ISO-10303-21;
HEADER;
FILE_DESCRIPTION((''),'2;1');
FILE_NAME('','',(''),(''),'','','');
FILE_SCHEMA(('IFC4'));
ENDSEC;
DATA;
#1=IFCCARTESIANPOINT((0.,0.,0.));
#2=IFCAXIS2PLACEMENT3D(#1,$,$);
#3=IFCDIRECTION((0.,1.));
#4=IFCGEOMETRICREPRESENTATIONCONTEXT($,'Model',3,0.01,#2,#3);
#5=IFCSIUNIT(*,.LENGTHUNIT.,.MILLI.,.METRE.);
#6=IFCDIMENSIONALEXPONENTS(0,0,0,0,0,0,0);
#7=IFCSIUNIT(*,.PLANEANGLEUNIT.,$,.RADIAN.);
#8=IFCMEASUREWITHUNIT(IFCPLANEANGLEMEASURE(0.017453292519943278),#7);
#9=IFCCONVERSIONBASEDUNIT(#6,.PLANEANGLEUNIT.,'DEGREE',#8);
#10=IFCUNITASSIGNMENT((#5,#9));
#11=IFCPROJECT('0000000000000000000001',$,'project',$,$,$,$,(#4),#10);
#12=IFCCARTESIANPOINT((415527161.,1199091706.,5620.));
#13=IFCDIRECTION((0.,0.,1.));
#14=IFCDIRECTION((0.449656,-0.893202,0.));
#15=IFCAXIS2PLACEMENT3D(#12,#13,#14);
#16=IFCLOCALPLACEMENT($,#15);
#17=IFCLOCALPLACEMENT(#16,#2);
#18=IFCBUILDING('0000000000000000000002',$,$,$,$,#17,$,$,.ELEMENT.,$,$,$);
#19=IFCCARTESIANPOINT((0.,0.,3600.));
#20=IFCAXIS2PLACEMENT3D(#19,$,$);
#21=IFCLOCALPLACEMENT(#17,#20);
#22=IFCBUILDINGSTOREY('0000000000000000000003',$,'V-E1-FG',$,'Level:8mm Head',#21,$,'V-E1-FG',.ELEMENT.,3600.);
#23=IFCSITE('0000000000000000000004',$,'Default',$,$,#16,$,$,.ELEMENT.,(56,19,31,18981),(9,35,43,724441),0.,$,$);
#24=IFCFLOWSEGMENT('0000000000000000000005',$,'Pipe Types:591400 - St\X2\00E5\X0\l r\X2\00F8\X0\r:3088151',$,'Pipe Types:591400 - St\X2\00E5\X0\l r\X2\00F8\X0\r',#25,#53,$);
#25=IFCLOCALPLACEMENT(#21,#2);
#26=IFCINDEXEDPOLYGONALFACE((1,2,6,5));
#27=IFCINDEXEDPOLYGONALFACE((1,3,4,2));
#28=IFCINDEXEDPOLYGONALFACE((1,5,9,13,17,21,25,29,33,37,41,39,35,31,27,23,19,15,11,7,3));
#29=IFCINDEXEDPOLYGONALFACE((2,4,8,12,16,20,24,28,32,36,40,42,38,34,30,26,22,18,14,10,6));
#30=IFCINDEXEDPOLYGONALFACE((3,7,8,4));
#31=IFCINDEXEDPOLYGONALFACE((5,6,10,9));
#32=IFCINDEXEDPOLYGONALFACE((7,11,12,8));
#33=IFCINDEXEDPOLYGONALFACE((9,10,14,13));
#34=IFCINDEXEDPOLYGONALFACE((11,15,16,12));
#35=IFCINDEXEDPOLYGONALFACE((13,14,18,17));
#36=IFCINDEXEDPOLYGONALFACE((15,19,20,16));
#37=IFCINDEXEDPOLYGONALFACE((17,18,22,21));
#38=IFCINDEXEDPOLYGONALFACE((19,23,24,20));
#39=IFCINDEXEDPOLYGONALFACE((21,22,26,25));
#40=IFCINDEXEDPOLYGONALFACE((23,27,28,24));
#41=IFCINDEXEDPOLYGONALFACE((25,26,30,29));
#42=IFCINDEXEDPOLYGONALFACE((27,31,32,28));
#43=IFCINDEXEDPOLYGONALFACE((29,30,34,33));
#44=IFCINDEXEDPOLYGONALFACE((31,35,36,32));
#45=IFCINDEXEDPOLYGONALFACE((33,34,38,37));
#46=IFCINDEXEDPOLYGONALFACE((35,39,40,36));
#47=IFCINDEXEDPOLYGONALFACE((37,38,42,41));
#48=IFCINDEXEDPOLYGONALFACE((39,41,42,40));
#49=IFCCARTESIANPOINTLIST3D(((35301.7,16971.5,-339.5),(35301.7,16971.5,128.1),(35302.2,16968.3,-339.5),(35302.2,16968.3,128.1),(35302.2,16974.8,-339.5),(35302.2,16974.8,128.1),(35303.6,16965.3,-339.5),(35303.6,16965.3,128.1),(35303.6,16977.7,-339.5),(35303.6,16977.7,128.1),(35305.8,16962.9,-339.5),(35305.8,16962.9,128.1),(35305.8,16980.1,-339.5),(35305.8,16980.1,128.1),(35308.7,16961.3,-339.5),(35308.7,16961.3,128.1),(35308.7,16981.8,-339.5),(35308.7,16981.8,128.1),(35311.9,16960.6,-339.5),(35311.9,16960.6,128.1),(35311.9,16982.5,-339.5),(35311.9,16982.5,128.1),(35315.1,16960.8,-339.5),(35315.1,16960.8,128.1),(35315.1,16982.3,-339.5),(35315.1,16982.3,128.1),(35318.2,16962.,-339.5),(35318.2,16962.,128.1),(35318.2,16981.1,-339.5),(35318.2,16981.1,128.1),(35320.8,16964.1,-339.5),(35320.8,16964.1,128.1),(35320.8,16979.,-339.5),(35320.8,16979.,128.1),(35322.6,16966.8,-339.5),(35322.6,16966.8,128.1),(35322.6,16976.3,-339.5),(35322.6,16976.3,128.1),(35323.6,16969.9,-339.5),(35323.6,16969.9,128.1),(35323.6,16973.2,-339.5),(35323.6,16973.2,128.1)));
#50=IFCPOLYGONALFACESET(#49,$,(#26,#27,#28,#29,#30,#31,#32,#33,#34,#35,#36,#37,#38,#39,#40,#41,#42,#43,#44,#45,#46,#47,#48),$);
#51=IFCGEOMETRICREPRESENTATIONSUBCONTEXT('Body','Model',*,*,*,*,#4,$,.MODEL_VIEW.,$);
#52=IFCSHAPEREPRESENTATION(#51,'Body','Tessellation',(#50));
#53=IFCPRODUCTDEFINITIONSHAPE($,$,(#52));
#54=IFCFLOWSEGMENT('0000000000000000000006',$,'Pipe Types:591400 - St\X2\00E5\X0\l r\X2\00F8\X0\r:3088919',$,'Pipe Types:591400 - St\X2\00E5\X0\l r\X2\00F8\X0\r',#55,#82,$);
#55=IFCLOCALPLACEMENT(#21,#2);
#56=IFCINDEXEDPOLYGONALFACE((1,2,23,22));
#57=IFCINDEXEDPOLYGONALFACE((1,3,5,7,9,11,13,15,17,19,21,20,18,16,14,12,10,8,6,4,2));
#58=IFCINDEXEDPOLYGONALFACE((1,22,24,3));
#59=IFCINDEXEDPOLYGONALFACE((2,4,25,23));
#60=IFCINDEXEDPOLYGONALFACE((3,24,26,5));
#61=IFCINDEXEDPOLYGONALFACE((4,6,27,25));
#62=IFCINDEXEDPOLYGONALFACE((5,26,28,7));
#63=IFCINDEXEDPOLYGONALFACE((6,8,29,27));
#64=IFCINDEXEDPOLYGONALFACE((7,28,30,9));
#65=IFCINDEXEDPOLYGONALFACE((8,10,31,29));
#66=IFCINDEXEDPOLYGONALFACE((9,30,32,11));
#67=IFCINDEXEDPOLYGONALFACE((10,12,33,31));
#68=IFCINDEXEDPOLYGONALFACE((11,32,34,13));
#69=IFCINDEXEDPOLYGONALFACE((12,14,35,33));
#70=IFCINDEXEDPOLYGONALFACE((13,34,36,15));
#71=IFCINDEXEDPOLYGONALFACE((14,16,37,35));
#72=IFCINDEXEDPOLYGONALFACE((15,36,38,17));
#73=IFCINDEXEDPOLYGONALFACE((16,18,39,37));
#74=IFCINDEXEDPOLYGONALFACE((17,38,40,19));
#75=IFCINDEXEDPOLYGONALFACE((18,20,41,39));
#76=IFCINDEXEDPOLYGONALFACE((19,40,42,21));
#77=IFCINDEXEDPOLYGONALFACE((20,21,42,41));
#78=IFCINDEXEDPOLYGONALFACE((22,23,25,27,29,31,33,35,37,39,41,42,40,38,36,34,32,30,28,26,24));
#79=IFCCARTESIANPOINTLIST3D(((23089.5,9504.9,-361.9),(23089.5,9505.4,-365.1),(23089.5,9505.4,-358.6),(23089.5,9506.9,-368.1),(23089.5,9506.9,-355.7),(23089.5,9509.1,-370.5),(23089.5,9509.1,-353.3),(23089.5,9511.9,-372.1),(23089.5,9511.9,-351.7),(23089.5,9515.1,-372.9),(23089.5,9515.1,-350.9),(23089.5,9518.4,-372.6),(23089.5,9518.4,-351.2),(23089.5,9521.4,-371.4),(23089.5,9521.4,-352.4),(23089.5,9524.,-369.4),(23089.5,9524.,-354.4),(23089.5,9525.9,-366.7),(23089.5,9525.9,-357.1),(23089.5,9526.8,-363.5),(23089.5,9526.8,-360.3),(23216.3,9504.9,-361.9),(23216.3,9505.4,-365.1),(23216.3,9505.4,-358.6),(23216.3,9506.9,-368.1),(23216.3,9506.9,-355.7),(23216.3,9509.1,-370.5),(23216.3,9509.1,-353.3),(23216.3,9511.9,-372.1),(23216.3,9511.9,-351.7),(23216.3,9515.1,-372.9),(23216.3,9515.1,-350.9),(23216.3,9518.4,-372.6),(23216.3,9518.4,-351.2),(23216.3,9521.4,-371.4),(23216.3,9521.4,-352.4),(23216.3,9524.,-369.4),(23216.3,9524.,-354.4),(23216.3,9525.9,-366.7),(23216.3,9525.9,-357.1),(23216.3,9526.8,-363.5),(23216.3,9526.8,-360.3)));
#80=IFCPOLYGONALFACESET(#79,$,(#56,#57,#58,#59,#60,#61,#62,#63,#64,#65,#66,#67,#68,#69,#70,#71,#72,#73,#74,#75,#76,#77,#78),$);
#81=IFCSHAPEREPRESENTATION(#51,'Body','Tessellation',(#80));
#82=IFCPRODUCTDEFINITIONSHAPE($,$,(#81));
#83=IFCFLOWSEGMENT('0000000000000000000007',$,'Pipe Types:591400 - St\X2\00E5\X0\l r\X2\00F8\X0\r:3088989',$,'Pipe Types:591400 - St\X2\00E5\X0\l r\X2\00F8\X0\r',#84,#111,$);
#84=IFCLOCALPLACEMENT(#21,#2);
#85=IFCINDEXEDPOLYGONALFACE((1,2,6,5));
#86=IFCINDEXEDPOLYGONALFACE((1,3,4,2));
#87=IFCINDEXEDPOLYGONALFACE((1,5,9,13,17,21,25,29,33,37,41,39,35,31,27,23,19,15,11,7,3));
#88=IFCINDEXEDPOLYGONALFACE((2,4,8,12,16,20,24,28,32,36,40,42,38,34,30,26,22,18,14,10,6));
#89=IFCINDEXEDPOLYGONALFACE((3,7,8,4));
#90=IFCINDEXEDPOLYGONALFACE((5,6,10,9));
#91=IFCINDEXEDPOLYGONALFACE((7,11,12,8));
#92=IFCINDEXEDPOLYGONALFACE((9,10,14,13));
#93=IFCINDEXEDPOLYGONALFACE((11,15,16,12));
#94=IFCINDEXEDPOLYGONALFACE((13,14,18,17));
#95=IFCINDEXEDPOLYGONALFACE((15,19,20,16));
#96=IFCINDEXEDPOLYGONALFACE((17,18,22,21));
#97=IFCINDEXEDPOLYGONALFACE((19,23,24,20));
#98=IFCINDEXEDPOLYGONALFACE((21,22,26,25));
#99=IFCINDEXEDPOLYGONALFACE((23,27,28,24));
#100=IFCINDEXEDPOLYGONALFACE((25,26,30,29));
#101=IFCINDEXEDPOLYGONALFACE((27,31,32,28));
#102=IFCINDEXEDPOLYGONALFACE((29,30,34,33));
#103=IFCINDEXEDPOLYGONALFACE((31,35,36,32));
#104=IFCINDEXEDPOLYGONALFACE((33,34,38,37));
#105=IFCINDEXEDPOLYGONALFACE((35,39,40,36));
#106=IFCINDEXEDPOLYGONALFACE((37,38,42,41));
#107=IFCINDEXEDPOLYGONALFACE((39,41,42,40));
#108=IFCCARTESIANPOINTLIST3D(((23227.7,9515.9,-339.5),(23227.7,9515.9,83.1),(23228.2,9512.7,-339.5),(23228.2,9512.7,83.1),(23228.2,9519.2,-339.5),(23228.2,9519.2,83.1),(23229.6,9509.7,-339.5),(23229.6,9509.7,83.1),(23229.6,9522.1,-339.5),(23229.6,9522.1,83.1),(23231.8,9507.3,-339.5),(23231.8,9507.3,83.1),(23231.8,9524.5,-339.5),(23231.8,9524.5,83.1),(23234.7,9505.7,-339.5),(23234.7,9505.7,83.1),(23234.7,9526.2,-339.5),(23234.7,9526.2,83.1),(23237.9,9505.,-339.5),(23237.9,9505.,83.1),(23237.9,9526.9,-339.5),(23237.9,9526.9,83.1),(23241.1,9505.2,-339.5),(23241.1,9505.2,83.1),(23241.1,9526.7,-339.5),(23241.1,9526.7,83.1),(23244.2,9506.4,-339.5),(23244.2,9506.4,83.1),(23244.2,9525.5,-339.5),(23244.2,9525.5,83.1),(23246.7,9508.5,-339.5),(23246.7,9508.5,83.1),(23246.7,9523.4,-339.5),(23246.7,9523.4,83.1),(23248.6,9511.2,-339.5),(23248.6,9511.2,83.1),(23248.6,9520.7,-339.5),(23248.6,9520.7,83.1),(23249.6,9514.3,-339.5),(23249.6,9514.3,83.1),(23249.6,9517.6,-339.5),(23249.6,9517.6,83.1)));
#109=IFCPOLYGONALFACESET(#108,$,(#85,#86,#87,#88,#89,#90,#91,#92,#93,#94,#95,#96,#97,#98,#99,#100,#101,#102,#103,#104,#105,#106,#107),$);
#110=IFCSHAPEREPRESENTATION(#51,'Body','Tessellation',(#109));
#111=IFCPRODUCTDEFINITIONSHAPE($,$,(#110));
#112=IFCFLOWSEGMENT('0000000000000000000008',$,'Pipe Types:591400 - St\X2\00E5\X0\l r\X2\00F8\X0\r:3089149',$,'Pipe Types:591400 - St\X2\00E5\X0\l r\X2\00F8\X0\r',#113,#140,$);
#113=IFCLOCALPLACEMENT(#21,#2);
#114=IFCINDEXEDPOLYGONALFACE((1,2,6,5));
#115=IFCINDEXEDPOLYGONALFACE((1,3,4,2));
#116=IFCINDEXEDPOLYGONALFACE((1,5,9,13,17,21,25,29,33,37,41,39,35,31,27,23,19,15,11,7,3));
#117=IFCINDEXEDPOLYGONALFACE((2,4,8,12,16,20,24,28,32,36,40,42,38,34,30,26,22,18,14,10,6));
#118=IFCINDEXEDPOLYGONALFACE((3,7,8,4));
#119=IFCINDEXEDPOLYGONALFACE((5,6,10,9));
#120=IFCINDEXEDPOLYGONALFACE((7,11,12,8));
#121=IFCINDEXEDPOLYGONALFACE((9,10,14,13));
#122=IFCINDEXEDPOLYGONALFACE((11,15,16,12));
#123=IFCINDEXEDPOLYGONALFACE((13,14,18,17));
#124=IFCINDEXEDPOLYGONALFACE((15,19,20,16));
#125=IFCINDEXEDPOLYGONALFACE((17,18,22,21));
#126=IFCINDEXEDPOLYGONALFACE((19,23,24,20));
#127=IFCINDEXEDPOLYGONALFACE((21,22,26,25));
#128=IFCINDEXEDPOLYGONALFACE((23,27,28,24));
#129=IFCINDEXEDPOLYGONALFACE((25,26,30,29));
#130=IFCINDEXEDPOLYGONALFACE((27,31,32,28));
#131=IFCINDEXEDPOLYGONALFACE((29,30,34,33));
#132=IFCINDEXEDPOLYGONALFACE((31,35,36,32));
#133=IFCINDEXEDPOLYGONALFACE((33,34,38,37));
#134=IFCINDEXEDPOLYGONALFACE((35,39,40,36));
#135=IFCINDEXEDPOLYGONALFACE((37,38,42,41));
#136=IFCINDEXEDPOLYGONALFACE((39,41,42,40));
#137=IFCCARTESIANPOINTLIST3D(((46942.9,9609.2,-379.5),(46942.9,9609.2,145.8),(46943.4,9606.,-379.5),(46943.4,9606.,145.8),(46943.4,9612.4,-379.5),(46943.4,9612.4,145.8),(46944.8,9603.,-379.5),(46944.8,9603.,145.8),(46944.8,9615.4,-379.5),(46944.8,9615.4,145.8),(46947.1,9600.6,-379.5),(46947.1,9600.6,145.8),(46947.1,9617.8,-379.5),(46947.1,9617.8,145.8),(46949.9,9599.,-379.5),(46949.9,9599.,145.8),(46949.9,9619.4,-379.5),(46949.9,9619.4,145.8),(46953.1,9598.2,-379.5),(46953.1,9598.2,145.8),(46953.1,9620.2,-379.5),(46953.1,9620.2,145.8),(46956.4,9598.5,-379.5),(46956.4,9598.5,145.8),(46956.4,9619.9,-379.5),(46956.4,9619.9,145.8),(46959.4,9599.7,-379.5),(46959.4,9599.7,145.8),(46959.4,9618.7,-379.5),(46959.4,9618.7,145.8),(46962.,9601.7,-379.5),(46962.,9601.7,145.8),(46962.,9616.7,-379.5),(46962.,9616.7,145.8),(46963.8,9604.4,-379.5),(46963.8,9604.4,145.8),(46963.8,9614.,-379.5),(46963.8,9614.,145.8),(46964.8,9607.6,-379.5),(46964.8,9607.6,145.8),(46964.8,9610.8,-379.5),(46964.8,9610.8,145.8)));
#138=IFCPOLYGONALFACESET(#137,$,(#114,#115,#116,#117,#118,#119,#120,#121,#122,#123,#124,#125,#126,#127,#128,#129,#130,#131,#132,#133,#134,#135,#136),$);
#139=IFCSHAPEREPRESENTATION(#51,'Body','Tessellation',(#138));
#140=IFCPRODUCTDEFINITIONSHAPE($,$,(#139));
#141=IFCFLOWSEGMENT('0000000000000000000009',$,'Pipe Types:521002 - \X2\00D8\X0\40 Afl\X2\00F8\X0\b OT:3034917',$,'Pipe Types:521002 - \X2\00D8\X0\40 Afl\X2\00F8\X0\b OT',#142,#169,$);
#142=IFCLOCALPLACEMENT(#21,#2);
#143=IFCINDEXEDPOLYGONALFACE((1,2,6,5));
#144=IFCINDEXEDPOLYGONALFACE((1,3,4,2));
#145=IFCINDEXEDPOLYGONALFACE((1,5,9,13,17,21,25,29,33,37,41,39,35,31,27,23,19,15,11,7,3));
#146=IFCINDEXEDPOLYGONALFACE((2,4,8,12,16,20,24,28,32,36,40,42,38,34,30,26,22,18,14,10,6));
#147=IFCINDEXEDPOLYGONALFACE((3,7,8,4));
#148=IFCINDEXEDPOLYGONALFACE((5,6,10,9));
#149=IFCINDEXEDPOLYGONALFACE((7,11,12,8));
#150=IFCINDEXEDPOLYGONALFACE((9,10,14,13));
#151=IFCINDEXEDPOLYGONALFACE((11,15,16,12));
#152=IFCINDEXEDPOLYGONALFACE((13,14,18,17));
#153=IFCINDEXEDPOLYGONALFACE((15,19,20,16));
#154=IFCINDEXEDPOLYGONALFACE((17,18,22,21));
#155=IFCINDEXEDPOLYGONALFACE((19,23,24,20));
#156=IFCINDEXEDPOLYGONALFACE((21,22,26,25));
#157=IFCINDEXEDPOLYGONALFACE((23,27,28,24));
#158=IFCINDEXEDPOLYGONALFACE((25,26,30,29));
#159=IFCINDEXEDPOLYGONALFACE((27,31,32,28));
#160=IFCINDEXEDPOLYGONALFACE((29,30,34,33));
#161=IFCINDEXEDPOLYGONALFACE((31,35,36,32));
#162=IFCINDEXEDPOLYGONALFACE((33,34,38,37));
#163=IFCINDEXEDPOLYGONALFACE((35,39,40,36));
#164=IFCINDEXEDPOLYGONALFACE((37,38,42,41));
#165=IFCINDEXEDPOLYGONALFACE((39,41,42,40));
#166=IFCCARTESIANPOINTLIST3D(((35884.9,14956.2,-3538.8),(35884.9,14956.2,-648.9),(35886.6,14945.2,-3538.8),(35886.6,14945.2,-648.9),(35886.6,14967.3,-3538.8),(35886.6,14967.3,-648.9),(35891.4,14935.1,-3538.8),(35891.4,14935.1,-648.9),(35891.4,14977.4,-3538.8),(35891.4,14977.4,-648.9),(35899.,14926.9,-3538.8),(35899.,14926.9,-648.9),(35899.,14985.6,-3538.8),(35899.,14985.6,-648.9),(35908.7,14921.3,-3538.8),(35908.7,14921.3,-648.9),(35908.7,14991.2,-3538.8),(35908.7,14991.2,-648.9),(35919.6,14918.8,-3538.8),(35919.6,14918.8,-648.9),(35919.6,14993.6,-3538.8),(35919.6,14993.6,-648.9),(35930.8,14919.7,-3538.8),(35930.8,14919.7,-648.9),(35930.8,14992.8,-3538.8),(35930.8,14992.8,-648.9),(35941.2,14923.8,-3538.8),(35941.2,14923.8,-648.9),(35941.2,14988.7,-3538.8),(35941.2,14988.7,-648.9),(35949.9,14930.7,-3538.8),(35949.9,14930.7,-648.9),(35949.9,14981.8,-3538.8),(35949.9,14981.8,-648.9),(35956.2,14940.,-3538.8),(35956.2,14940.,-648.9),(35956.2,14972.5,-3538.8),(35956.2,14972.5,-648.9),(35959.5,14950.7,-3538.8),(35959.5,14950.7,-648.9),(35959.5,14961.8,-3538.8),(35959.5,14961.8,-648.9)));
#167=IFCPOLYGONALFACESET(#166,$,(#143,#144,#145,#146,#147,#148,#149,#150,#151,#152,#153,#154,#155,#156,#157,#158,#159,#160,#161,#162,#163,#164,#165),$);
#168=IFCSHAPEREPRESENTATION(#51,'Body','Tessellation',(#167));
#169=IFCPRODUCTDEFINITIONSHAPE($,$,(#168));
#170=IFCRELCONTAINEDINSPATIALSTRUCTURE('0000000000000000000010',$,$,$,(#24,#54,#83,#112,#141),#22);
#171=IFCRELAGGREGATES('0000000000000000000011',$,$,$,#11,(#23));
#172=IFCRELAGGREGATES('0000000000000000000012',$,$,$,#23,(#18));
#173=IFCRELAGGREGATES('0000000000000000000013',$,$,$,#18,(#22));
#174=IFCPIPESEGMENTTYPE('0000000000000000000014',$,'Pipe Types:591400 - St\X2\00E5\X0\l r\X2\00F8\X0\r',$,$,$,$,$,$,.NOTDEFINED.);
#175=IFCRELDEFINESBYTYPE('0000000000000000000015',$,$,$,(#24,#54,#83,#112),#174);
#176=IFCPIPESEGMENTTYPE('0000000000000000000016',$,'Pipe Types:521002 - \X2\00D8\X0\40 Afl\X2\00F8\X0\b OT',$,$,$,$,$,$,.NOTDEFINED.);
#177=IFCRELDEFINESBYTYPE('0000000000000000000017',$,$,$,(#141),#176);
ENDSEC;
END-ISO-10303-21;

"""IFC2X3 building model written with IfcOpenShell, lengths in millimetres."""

from ifc_helpers import new_model, entity, si_unit, converted_unit, direction, frame, frame_2d, origin, origin_2d_with_axis, place, context, subcontext, project, spatial, circle, extrude, type_object, element, save


model = new_model("IFC2X3")

# Units and contexts
model_context = context("Model", 3, precision=0.01, world=origin(), true_north=direction((0.0, 1.0)))
body_context = subcontext(model_context, "Body", "Model", "MODEL_VIEW")
ifc_project = project(units=[si_unit("LENGTHUNIT", "METRE", prefix="MILLI"), converted_unit("PLANEANGLEUNIT", "DEGREE", entity("IfcPlaneAngleMeasure", 0.017453292519943278), si_unit("PLANEANGLEUNIT", "RADIAN"), dimensions=[0, 0, 0, 0, 0, 0, 0])], contexts=[model_context])

# Site, building, storey
site_placement = place(None, frame((415527161.0, 1199091706.0, 5620.0), z_axis=(0.0, 0.0, 1.0), x_axis=(0.449656, -0.893202, 0.0)))
site = spatial("IfcSite", under=ifc_project, at=site_placement, Name="Default", CompositionType="ELEMENT", RefLatitude=(56, 19, 31, 18981), RefLongitude=(9, 35, 43, 724441), RefElevation=0.0)
building_placement = place(site_placement, origin())
building = spatial("IfcBuilding", under=site, at=building_placement, CompositionType="ELEMENT")
storey_placement = place(building_placement, frame((0.0, 0.0, 3600.0)))
storey = spatial("IfcBuildingStorey", under=building, at=storey_placement, Name="V-E1-FG", ObjectType="Level:8mm Head", LongName="V-E1-FG", CompositionType="ELEMENT", Elevation=3600.0)

# Flow segments
pipe_segment_type_1 = type_object("IfcPipeSegmentType", Name="Pipe Types:591400 - Stål rør", PredefinedType="NOTDEFINED")
flow_segment_1_placement = place(storey_placement, origin())
element("IfcFlowSegment", 1, at=flow_segment_1_placement, inside=storey, type_object=pipe_segment_type_1, Name="Pipe Types:591400 - Stål rør:3088151", ObjectType="Pipe Types:591400 - Stål rør", context=body_context, shape_type="SweptSolid", body=[
    extrude(circle(Radius=11.0, at=origin_2d_with_axis()), frame((35312.7, 16971.5, -339.5), z_axis=(0.0, 0.0, 1.0), x_axis=(-1.0, 0.0, 0.0)), (0.0, 0.0, 1.0), 467.7),
])
flow_segment_2_placement = place(storey_placement, origin())
element("IfcFlowSegment", 2, at=flow_segment_2_placement, inside=storey, type_object=pipe_segment_type_1, Name="Pipe Types:591400 - Stål rør:3088919", ObjectType="Pipe Types:591400 - Stål rør", context=body_context, shape_type="SweptSolid", body=[
    extrude(circle(Radius=11.0, at=frame_2d((0.0, 0.0), x_axis=(1.0, 0.0))), frame((23089.5, 9515.9, -361.9), z_axis=(1.0, 0.0, 0.0), x_axis=(0.0, -1.0, 0.0)), (0.0, 0.0, 1.0), 126.8),
])
flow_segment_3_placement = place(storey_placement, origin())
element("IfcFlowSegment", 3, at=flow_segment_3_placement, inside=storey, type_object=pipe_segment_type_1, Name="Pipe Types:591400 - Stål rør:3088989", ObjectType="Pipe Types:591400 - Stål rør", context=body_context, shape_type="SweptSolid", body=[
    extrude(circle(Radius=11.0, at=origin_2d_with_axis()), frame((23238.7, 9515.9, -339.5), z_axis=(0.0, 0.0, 1.0), x_axis=(-1.0, 0.0, 0.0)), (0.0, 0.0, 1.0), 422.7),
])
flow_segment_4_placement = place(storey_placement, origin())
element("IfcFlowSegment", 4, at=flow_segment_4_placement, inside=storey, type_object=pipe_segment_type_1, Name="Pipe Types:591400 - Stål rør:3089149", ObjectType="Pipe Types:591400 - Stål rør", context=body_context, shape_type="SweptSolid", body=[
    extrude(circle(Radius=11.0, at=origin_2d_with_axis()), frame((46953.9, 9609.2, -379.5), z_axis=(0.0, 0.0, 1.0), x_axis=(-1.0, 0.0, 0.0)), (0.0, 0.0, 1.0), 525.3),
])
pipe_segment_type_2 = type_object("IfcPipeSegmentType", Name="Pipe Types:521002 - Ø40 Afløb OT", PredefinedType="NOTDEFINED")
flow_segment_5_placement = place(storey_placement, origin())
element("IfcFlowSegment", 5, at=flow_segment_5_placement, inside=storey, type_object=pipe_segment_type_2, Name="Pipe Types:521002 - Ø40 Afløb OT:3034917", ObjectType="Pipe Types:521002 - Ø40 Afløb OT", context=body_context, shape_type="SweptSolid", body=[
    extrude(circle(Radius=37.5, at=origin_2d_with_axis()), frame((35922.4, 14956.2, -3538.8), z_axis=(0.0, 0.0, 1.0), x_axis=(-1.0, 0.0, 0.0)), (0.0, 0.0, 1.0), 2890.0),
])

save(model, "model.ifc")
